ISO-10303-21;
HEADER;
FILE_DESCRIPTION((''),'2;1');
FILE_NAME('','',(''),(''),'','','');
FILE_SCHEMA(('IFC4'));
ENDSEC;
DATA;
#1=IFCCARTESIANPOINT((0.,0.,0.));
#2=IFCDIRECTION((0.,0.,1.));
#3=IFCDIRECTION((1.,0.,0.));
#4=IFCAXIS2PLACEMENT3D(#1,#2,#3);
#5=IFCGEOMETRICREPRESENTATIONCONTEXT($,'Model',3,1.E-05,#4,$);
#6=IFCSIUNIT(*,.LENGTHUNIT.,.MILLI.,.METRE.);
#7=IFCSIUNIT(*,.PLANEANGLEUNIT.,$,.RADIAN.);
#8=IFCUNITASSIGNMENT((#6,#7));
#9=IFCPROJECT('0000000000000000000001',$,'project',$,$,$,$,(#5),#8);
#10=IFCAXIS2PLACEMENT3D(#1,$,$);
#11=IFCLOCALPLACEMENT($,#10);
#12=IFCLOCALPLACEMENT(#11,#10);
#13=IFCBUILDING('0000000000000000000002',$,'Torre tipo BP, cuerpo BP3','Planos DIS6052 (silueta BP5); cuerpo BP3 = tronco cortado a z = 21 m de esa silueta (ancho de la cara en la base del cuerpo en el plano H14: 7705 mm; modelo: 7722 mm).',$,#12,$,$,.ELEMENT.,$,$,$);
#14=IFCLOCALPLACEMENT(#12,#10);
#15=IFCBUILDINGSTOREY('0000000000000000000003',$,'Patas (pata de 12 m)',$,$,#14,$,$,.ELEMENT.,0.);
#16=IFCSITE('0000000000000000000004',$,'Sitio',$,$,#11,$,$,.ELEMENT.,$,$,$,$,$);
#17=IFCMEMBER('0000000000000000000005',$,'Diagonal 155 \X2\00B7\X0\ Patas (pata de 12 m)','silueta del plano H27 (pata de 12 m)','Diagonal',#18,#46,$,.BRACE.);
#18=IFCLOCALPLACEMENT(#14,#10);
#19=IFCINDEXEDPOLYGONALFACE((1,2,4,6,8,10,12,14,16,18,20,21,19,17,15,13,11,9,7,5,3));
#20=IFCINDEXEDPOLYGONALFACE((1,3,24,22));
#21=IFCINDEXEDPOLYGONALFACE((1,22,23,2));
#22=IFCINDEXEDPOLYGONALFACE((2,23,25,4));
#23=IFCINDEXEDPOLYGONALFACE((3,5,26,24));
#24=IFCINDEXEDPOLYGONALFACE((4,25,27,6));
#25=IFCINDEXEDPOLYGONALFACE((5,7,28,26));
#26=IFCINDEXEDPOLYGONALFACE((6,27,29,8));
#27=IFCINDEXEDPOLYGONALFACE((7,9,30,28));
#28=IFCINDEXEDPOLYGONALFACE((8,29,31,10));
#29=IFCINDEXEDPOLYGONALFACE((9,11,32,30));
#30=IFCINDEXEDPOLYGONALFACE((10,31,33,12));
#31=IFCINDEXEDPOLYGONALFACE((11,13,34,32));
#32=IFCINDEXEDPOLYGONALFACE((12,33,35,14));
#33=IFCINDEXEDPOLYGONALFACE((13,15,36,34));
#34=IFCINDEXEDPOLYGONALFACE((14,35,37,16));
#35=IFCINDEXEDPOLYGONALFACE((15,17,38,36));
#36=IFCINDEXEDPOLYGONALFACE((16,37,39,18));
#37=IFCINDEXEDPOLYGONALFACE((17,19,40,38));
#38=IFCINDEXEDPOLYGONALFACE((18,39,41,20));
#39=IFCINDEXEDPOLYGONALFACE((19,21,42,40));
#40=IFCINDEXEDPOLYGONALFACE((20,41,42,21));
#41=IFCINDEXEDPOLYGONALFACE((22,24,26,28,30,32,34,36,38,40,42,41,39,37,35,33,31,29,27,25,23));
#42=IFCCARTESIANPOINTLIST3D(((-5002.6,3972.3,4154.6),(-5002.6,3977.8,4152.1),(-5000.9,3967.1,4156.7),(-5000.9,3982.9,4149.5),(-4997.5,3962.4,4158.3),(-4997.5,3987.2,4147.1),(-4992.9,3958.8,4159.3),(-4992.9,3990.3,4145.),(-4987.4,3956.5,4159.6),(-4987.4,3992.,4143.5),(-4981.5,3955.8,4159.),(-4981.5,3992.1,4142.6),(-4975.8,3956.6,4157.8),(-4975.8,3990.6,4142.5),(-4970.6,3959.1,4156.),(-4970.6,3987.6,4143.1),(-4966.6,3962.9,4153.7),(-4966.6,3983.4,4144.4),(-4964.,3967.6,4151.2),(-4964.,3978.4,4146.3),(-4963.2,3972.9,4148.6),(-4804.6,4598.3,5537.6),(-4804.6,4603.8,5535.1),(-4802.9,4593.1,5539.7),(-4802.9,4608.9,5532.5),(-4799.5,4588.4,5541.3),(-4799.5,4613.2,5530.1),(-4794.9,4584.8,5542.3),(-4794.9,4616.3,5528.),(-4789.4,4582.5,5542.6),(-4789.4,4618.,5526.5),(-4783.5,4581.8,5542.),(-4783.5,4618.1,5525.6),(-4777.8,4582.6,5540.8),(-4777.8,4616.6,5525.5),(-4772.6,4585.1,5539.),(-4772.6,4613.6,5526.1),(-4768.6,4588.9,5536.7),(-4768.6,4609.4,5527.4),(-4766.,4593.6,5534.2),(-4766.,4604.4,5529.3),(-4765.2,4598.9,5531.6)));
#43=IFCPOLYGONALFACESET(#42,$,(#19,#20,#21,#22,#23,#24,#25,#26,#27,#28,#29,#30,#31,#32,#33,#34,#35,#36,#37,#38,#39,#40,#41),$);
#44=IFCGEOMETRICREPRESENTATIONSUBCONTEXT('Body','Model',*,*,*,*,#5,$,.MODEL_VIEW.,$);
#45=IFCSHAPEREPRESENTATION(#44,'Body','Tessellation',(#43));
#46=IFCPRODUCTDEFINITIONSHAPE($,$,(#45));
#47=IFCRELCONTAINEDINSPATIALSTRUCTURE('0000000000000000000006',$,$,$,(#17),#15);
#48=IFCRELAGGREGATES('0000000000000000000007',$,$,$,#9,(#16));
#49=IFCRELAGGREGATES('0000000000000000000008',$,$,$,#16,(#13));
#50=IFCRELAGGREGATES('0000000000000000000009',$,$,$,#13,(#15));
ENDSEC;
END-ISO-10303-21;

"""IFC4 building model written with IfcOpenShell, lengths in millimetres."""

from ifc_helpers import new_model, si_unit, frame, origin, origin_with_axes, place, context, subcontext, project, spatial, circle, extrude, element, save


model = new_model("IFC4")

# Units and contexts
model_context = context("Model", 3, precision=1e-05, world=origin_with_axes())
body_context = subcontext(model_context, "Body", "Model", "MODEL_VIEW")
ifc_project = project(units=[si_unit("LENGTHUNIT", "METRE", prefix="MILLI"), si_unit("PLANEANGLEUNIT", "RADIAN")], contexts=[model_context])

# Site, building, storey
site_placement = place(None, origin())
site = spatial("IfcSite", under=ifc_project, at=site_placement, Name="Sitio", CompositionType="ELEMENT")
building_placement = place(site_placement, origin())
building = spatial("IfcBuilding", under=site, at=building_placement, Name="Torre tipo BP, cuerpo BP3", Description="Planos DIS6052 (silueta BP5); cuerpo BP3 = tronco cortado a z = 21 m de esa silueta (ancho de la cara en la base del cuerpo en el plano H14: 7705 mm; modelo: 7722 mm).", CompositionType="ELEMENT")
storey_placement = place(building_placement, origin())
storey = spatial("IfcBuildingStorey", under=building, at=storey_placement, Name="Patas (pata de 12 m)", CompositionType="ELEMENT", Elevation=0.0)

# Member
member_1_placement = place(storey_placement, frame((-4983.0, 3974.0, 4151.0), z_axis=(0.129333, 0.4089, 0.903368), x_axis=(0.991601, -0.053332, -0.117824)))
element("IfcMember", 1, at=member_1_placement, inside=storey, Name="Diagonal 155 · Patas (pata de 12 m)", Description="silueta del plano H27 (pata de 12 m)", ObjectType="Diagonal", PredefinedType="BRACE", context=body_context, shape_type="SweptSolid", body=[
    extrude(circle(Radius=20.0), None, (0.0, 0.0, 1.0), 1530.9),
])

save(model, "model.ifc")
